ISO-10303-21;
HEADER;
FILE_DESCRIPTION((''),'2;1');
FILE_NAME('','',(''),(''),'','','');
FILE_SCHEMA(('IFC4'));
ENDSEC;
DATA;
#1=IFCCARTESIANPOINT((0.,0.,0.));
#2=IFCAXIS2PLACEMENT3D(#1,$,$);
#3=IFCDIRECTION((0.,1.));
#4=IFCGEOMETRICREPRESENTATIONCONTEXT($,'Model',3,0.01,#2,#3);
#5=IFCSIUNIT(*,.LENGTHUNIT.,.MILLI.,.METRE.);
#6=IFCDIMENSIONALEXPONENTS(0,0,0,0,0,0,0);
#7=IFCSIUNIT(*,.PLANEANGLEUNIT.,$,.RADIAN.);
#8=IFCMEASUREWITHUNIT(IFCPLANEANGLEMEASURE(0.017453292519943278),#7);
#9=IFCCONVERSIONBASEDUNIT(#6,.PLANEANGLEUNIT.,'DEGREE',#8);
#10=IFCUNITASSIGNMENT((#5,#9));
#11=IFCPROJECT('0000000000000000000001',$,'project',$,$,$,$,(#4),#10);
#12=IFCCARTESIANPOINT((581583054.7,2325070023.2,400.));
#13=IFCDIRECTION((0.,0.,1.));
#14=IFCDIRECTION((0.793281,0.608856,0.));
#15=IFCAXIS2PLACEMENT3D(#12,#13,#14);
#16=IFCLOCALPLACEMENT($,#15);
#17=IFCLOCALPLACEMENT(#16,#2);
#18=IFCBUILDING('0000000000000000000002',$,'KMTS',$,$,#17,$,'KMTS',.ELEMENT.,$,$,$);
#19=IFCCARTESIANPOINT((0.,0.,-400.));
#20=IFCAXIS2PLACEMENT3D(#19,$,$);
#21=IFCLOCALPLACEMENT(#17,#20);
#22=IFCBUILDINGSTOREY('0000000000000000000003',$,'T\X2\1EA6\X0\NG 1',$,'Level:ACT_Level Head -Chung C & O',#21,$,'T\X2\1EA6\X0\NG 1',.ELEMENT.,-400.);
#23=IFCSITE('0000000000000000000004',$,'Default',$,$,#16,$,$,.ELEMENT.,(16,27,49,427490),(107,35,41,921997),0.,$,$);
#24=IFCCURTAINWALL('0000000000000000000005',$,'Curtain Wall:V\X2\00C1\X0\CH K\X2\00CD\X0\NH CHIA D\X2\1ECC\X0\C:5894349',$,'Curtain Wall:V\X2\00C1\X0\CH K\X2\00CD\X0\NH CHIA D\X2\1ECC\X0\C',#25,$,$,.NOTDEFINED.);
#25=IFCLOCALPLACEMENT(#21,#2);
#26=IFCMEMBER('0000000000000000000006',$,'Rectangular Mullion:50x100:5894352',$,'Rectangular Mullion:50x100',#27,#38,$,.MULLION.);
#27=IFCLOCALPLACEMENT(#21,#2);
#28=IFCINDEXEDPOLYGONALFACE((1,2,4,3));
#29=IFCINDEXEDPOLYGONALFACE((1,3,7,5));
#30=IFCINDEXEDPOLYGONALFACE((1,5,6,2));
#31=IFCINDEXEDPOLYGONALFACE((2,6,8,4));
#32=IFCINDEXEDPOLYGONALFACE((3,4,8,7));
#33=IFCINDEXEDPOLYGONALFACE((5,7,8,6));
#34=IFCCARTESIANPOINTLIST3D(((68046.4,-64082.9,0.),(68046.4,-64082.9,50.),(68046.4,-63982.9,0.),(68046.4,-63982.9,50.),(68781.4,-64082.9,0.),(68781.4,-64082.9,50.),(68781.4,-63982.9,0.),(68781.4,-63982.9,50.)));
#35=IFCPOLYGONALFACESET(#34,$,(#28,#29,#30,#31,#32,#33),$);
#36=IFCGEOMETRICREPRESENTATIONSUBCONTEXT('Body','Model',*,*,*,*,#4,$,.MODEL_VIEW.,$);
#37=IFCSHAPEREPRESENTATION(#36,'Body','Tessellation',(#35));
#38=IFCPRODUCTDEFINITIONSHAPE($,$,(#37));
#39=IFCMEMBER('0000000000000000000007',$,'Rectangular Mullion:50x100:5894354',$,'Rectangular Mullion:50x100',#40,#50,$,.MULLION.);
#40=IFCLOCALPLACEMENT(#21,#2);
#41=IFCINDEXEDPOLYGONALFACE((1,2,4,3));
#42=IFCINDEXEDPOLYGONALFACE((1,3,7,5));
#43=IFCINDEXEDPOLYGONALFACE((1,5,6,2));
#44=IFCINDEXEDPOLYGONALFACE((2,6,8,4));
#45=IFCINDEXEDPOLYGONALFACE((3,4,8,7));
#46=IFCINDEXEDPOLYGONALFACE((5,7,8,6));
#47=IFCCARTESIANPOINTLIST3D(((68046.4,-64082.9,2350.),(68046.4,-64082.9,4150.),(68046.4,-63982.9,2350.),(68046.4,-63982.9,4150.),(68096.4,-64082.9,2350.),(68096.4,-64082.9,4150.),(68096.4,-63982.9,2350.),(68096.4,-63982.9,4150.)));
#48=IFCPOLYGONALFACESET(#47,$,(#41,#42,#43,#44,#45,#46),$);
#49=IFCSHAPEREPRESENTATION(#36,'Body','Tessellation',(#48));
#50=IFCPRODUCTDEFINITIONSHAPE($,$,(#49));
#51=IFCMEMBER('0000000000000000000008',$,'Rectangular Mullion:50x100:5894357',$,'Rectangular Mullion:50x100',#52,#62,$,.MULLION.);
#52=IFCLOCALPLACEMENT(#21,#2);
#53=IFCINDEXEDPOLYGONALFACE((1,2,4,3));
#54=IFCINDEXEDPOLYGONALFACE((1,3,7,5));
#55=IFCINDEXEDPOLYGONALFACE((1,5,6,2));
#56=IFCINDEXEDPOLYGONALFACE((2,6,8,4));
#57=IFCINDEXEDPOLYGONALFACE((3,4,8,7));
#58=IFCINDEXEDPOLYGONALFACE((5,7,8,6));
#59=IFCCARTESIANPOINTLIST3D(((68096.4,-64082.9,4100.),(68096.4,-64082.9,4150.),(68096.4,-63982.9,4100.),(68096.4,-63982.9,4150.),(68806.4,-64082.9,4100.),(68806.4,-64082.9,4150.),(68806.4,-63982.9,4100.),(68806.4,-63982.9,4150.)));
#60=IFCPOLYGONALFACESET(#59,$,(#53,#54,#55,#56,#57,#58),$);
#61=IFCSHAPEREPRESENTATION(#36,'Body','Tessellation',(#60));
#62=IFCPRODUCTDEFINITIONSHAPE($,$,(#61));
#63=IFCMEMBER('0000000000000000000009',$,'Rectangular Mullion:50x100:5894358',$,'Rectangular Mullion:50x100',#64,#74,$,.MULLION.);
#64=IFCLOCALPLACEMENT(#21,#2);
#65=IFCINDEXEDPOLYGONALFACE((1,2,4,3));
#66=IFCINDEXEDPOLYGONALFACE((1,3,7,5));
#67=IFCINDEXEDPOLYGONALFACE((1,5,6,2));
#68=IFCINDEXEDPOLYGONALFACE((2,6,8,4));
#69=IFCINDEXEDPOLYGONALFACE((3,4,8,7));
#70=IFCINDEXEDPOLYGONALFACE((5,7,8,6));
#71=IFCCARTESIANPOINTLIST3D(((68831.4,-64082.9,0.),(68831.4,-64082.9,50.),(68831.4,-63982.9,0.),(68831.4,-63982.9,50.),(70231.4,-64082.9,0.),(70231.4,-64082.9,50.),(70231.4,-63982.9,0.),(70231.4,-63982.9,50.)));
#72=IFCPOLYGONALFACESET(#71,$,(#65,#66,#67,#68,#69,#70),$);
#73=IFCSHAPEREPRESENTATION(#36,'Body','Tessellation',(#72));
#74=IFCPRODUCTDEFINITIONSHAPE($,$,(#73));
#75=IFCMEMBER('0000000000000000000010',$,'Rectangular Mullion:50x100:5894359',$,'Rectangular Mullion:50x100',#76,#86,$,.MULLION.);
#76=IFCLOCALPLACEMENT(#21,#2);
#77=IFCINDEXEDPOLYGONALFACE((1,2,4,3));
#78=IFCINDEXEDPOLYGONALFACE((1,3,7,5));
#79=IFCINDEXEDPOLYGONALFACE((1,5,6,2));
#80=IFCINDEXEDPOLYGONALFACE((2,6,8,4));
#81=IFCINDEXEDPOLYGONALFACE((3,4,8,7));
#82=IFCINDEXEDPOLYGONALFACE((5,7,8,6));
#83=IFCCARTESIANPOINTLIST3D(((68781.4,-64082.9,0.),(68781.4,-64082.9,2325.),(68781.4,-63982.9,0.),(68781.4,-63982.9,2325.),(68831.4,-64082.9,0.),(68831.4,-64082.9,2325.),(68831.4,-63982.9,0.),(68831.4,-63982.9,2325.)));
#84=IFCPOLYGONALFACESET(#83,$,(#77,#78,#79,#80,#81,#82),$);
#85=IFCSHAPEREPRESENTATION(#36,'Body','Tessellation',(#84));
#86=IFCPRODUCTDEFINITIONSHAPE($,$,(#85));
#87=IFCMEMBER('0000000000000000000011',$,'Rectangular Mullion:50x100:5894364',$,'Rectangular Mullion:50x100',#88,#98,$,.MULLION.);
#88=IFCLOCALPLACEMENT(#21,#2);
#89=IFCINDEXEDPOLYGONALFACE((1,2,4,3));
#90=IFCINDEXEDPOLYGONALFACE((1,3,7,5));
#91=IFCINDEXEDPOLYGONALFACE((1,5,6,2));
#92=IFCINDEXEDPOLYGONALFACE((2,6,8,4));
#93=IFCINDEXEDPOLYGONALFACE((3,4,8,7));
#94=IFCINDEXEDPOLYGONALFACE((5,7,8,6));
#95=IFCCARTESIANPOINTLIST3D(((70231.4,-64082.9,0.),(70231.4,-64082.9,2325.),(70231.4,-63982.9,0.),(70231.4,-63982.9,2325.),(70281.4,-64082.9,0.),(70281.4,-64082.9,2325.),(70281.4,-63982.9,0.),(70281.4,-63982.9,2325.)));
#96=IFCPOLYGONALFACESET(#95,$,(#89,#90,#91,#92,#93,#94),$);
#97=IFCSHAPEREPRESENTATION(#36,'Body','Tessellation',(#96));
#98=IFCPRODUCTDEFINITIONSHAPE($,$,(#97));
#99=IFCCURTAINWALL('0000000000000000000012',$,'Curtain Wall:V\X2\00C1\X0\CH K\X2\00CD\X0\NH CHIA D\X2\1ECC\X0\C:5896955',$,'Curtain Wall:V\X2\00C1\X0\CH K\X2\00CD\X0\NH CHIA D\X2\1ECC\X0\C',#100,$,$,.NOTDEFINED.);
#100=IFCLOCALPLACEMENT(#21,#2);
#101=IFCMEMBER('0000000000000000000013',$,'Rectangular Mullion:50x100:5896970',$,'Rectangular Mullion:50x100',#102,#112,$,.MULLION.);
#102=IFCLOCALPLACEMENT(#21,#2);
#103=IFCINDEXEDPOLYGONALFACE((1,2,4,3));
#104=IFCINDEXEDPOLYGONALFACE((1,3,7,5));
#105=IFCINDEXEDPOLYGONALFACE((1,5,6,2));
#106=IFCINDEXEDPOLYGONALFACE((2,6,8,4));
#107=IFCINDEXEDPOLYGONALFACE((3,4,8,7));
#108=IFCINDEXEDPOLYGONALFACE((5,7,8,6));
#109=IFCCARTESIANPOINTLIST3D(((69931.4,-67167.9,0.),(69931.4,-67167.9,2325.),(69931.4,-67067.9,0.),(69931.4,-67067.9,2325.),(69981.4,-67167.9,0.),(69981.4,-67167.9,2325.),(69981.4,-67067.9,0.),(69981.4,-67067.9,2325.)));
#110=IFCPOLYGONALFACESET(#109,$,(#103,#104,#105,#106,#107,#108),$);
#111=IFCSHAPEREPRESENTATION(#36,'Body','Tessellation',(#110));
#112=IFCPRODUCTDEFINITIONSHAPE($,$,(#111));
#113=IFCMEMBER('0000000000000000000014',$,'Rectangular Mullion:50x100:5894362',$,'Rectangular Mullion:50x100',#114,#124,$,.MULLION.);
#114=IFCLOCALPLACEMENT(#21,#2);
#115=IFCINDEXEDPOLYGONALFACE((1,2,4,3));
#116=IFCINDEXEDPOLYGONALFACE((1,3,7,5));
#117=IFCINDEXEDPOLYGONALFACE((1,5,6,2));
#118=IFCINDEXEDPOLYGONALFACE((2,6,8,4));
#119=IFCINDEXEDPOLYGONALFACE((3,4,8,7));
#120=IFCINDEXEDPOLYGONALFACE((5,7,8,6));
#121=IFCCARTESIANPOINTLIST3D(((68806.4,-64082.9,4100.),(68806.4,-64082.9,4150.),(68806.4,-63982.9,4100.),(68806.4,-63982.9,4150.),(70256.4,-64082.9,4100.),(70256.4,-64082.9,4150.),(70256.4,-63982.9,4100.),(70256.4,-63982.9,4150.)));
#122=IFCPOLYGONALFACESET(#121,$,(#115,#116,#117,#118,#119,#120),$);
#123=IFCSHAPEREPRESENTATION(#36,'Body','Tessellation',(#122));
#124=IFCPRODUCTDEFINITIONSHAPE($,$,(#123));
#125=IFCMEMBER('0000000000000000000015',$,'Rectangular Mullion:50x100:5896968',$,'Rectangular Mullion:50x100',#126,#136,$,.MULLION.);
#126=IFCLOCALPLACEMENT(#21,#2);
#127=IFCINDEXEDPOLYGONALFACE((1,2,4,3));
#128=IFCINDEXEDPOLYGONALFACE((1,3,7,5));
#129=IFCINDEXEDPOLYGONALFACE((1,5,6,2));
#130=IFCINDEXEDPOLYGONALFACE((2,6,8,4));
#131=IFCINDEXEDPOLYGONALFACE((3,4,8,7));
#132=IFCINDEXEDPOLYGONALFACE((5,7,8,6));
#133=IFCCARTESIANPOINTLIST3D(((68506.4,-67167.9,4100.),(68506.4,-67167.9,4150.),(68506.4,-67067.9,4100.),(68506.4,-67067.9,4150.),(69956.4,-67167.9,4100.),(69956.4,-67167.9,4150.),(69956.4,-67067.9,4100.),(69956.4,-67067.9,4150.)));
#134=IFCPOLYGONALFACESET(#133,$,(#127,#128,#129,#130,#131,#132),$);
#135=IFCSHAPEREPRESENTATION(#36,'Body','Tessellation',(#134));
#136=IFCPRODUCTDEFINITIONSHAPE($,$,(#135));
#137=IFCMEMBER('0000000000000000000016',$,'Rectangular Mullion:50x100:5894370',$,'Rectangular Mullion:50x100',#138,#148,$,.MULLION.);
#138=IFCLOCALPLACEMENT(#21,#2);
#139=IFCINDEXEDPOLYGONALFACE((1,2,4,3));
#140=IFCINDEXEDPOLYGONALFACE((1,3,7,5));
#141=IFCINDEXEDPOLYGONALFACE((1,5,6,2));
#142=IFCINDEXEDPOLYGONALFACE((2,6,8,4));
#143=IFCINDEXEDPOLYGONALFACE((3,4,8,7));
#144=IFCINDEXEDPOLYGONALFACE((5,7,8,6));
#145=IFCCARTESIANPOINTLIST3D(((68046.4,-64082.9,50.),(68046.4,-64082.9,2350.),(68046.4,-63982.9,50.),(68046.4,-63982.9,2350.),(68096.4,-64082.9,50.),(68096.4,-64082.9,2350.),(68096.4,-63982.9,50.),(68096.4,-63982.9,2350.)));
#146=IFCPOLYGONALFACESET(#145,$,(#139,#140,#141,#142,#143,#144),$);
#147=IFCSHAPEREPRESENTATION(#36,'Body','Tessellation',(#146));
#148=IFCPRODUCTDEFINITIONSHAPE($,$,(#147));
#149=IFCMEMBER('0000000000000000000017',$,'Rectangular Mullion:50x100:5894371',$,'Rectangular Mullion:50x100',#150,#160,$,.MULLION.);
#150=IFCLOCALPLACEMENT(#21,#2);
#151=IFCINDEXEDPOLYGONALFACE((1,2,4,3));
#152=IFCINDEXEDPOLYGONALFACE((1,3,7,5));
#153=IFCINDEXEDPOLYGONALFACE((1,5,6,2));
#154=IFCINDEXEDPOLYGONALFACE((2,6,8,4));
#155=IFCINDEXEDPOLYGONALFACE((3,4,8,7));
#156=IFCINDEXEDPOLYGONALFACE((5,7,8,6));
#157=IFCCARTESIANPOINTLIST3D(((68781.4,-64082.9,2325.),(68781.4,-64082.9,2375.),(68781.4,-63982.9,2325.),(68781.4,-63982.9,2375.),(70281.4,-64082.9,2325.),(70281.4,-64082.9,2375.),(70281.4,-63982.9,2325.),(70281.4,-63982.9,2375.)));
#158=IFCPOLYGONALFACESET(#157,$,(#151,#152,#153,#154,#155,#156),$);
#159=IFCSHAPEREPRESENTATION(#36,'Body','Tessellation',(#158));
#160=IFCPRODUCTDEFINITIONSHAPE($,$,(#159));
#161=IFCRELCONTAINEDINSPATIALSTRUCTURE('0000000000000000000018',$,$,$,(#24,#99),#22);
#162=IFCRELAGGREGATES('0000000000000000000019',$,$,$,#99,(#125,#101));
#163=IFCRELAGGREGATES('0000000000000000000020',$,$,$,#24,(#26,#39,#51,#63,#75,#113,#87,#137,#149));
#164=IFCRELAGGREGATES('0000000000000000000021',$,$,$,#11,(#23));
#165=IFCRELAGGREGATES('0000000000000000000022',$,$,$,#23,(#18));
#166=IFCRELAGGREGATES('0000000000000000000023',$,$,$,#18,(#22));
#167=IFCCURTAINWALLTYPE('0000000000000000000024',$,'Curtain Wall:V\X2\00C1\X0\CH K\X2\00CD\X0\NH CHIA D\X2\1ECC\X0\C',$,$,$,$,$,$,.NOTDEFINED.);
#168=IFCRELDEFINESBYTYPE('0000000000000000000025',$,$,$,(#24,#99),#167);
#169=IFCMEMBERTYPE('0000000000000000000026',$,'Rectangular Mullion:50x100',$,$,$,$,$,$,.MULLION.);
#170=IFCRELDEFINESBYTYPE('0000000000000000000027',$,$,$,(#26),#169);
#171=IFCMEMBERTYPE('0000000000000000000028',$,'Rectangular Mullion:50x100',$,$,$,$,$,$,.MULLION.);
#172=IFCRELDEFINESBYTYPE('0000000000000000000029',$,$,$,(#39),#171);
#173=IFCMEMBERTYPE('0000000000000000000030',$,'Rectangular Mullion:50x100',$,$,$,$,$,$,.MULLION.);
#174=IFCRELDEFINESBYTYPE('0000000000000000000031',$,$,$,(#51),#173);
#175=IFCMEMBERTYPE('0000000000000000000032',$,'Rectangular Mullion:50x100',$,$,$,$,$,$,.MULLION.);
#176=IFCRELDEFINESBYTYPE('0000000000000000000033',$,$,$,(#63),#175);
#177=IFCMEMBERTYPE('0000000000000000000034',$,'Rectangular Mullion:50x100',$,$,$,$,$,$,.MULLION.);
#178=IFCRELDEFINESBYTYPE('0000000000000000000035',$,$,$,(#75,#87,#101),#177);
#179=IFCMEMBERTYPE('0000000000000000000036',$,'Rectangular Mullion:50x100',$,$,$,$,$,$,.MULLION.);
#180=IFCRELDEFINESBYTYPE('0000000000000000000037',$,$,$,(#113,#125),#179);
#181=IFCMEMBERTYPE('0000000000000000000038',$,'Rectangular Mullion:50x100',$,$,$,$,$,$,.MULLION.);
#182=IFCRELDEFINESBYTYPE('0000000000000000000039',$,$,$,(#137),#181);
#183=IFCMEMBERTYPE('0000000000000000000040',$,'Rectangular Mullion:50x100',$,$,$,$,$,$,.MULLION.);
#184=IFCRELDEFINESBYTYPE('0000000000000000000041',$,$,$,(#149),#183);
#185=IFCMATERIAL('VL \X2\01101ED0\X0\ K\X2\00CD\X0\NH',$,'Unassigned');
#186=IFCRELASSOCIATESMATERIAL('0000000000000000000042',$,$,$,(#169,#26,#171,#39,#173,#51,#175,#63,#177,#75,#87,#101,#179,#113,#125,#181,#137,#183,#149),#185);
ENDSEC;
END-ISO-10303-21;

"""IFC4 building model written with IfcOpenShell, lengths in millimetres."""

from ifc_helpers import new_model, entity, si_unit, converted_unit, direction, frame, origin, place, context, subcontext, project, spatial, indexed_curve, outline, extrude, source, transform, mapped, material, type_object, type_shapes, element, aggregate, save


model = new_model("IFC4")

# Units and contexts
model_context = context("Model", 3, precision=0.01, world=origin(), true_north=direction((0.0, 1.0)))
body_context = subcontext(model_context, "Body", "Model", "MODEL_VIEW")
ifc_project = project(units=[si_unit("LENGTHUNIT", "METRE", prefix="MILLI"), converted_unit("PLANEANGLEUNIT", "DEGREE", entity("IfcPlaneAngleMeasure", 0.017453292519943278), si_unit("PLANEANGLEUNIT", "RADIAN"), dimensions=[0, 0, 0, 0, 0, 0, 0])], contexts=[model_context])

# Site, building, storey
site_placement = place(None, frame((581583054.7, 2325070023.2, 400.0), z_axis=(0.0, 0.0, 1.0), x_axis=(0.793281, 0.608856, 0.0)))
site = spatial("IfcSite", under=ifc_project, at=site_placement, Name="Default", CompositionType="ELEMENT", RefLatitude=(16, 27, 49, 427490), RefLongitude=(107, 35, 41, 921997), RefElevation=0.0)
building_placement = place(site_placement, origin())
building = spatial("IfcBuilding", under=site, at=building_placement, Name="KMTS", LongName="KMTS", CompositionType="ELEMENT")
storey_placement = place(building_placement, frame((0.0, 0.0, -400.0)))
storey = spatial("IfcBuildingStorey", under=building, at=storey_placement, Name="TẦNG 1", ObjectType="Level:ACT_Level Head -Chung C & O", LongName="TẦNG 1", CompositionType="ELEMENT", Elevation=-400.0)

# Curtain wall, members
curtain_wall_type = type_object("IfcCurtainWallType", Name="Curtain Wall:VÁCH KÍNH CHIA DỌC", PredefinedType="NOTDEFINED")
curtain_wall_1_placement = place(storey_placement, frame((0.0, 0.0, 400.0)))
curtain_wall_1 = element("IfcCurtainWall", 1, at=curtain_wall_1_placement, inside=storey, type_object=curtain_wall_type, Name="Curtain Wall:VÁCH KÍNH CHIA DỌC:5894349", ObjectType="Curtain Wall:VÁCH KÍNH CHIA DỌC", PredefinedType="NOTDEFINED")
ifc_material_1 = material(Name="VL ĐỐ KÍNH", Category="Unassigned")
member_type_1 = type_object("IfcMemberType", Name="Rectangular Mullion:50x100", PredefinedType="MULLION", material=ifc_material_1)
shared_shape_1 = source(origin(), body_context, "Body", "SweptSolid", [
    extrude(outline(indexed_curve([(-25.0, -50.0), (25.0, -50.0), (25.0, 50.0), (-25.0, 50.0), (-25.0, -50.0)], self_intersect=False)), frame((-25.0, 0.0, -735.0), z_axis=(0.0, 0.0, 1.0), x_axis=(-1.0, 0.0, 0.0)), (0.0, 0.0, 1.0), 735.0),
])
type_shapes(member_type_1, [shared_shape_1])
member_1_placement = place(curtain_wall_1_placement, frame((68046.4, -64032.9, -400.0), z_axis=(-1.0, 0.0, 0.0), x_axis=(0.0, 0.0, -1.0)))
member_1 = element("IfcMember", 2, at=member_1_placement, type_object=member_type_1, material=ifc_material_1, Name="Rectangular Mullion:50x100:5894352", ObjectType="Rectangular Mullion:50x100", PredefinedType="MULLION", context=body_context, shape_type="MappedRepresentation", body=[
    mapped(shared_shape_1, transform((0.0, 0.0, 0.0), scale=1.0)),
])
member_type_2 = type_object("IfcMemberType", Name="Rectangular Mullion:50x100", PredefinedType="MULLION", material=ifc_material_1)
shared_shape_2 = source(origin(), body_context, "Body", "SweptSolid", [
    extrude(outline(indexed_curve([(-25.0, -50.0), (25.0, -50.0), (25.0, 50.0), (-25.0, 50.0), (-25.0, -50.0)], self_intersect=False)), frame((-25.0, 0.0, -1800.0), z_axis=(0.0, 0.0, 1.0), x_axis=(-1.0, 0.0, 0.0)), (0.0, 0.0, 1.0), 1800.0),
])
type_shapes(member_type_2, [shared_shape_2])
member_2_placement = place(curtain_wall_1_placement, frame((68046.4, -64032.9, 3750.0), z_axis=(0.0, 0.0, 1.0), x_axis=(-1.0, 0.0, 0.0)))
member_2 = element("IfcMember", 3, at=member_2_placement, type_object=member_type_2, material=ifc_material_1, Name="Rectangular Mullion:50x100:5894354", ObjectType="Rectangular Mullion:50x100", PredefinedType="MULLION", context=body_context, shape_type="MappedRepresentation", body=[
    mapped(shared_shape_2, transform((0.0, 0.0, 0.0), scale=1.0)),
])
member_type_3 = type_object("IfcMemberType", Name="Rectangular Mullion:50x100", PredefinedType="MULLION", material=ifc_material_1)
shared_shape_3 = source(origin(), body_context, "Body", "SweptSolid", [
    extrude(outline(indexed_curve([(-25.0, -50.0), (25.0, -50.0), (25.0, 50.0), (-25.0, 50.0), (-25.0, -50.0)], self_intersect=False)), frame((-25.0, 0.0, -710.0), z_axis=(0.0, 0.0, 1.0), x_axis=(-1.0, 0.0, 0.0)), (0.0, 0.0, 1.0), 710.0),
])
type_shapes(member_type_3, [shared_shape_3])
member_3_placement = place(curtain_wall_1_placement, frame((68806.4, -64032.9, 3750.0), z_axis=(1.0, 0.0, 0.0), x_axis=(0.0, 0.0, 1.0)))
member_3 = element("IfcMember", 4, at=member_3_placement, type_object=member_type_3, material=ifc_material_1, Name="Rectangular Mullion:50x100:5894357", ObjectType="Rectangular Mullion:50x100", PredefinedType="MULLION", context=body_context, shape_type="MappedRepresentation", body=[
    mapped(shared_shape_3, transform((0.0, 0.0, 0.0), scale=1.0)),
])
member_type_4 = type_object("IfcMemberType", Name="Rectangular Mullion:50x100", PredefinedType="MULLION", material=ifc_material_1)
shared_shape_4 = source(origin(), body_context, "Body", "SweptSolid", [
    extrude(outline(indexed_curve([(-25.0, -50.0), (25.0, -50.0), (25.0, 50.0), (-25.0, 50.0), (-25.0, -50.0)], self_intersect=False)), frame((-25.0, 0.0, -1400.0), z_axis=(0.0, 0.0, 1.0), x_axis=(-1.0, 0.0, 0.0)), (0.0, 0.0, 1.0), 1400.0),
])
type_shapes(member_type_4, [shared_shape_4])
member_4_placement = place(curtain_wall_1_placement, frame((68831.4, -64032.9, -400.0), z_axis=(-1.0, 0.0, 0.0), x_axis=(0.0, 0.0, -1.0)))
member_4 = element("IfcMember", 5, at=member_4_placement, type_object=member_type_4, material=ifc_material_1, Name="Rectangular Mullion:50x100:5894358", ObjectType="Rectangular Mullion:50x100", PredefinedType="MULLION", context=body_context, shape_type="MappedRepresentation", body=[
    mapped(shared_shape_4, transform((0.0, 0.0, 0.0), scale=1.0)),
])
member_type_5 = type_object("IfcMemberType", Name="Rectangular Mullion:50x100", PredefinedType="MULLION", material=ifc_material_1)
shared_shape_5 = source(origin(), body_context, "Body", "SweptSolid", [
    extrude(outline(indexed_curve([(-25.0, -50.0), (25.0, -50.0), (25.0, 50.0), (-25.0, 50.0), (-25.0, -50.0)], self_intersect=False)), frame((0.0, 0.0, -2325.0), z_axis=(0.0, 0.0, 1.0), x_axis=(-1.0, 0.0, 0.0)), (0.0, 0.0, 1.0), 2325.0),
])
type_shapes(member_type_5, [shared_shape_5])
member_5_placement = place(curtain_wall_1_placement, frame((68806.4, -64032.9, -400.0), z_axis=(0.0, 0.0, -1.0), x_axis=(1.0, 0.0, 0.0)))
member_5 = element("IfcMember", 6, at=member_5_placement, type_object=member_type_5, material=ifc_material_1, Name="Rectangular Mullion:50x100:5894359", ObjectType="Rectangular Mullion:50x100", PredefinedType="MULLION", context=body_context, shape_type="MappedRepresentation", body=[
    mapped(shared_shape_5, transform((0.0, 0.0, 0.0), scale=1.0)),
])
member_6_placement = place(curtain_wall_1_placement, frame((70256.4, -64032.9, -400.0), z_axis=(0.0, 0.0, -1.0), x_axis=(1.0, 0.0, 0.0)))
member_6 = element("IfcMember", 7, at=member_6_placement, type_object=member_type_5, material=ifc_material_1, Name="Rectangular Mullion:50x100:5894364", ObjectType="Rectangular Mullion:50x100", PredefinedType="MULLION", context=body_context, shape_type="MappedRepresentation", body=[
    mapped(shared_shape_5, transform((0.0, 0.0, 0.0), scale=1.0)),
])

# Curtain wall, member
curtain_wall_2_placement = place(storey_placement, frame((0.0, 0.0, 400.0)))
curtain_wall_2 = element("IfcCurtainWall", 8, at=curtain_wall_2_placement, inside=storey, type_object=curtain_wall_type, Name="Curtain Wall:VÁCH KÍNH CHIA DỌC:5896955", ObjectType="Curtain Wall:VÁCH KÍNH CHIA DỌC", PredefinedType="NOTDEFINED")
member_7_placement = place(curtain_wall_2_placement, frame((69956.4, -67117.9, -400.0), z_axis=(0.0, 0.0, -1.0), x_axis=(1.0, 0.0, 0.0)))
member_7 = element("IfcMember", 9, at=member_7_placement, type_object=member_type_5, material=ifc_material_1, Name="Rectangular Mullion:50x100:5896970", ObjectType="Rectangular Mullion:50x100", PredefinedType="MULLION", context=body_context, shape_type="MappedRepresentation", body=[
    mapped(shared_shape_5, transform((0.0, 0.0, 0.0), scale=1.0)),
])

# Members
member_type_6 = type_object("IfcMemberType", Name="Rectangular Mullion:50x100", PredefinedType="MULLION", material=ifc_material_1)
shared_shape_6 = source(origin(), body_context, "Body", "SweptSolid", [
    extrude(outline(indexed_curve([(-25.0, -50.0), (25.0, -50.0), (25.0, 50.0), (-25.0, 50.0), (-25.0, -50.0)], self_intersect=False)), frame((-25.0, 0.0, -1450.0), z_axis=(0.0, 0.0, 1.0), x_axis=(-1.0, 0.0, 0.0)), (0.0, 0.0, 1.0), 1450.0),
])
type_shapes(member_type_6, [shared_shape_6])
member_8_placement = place(curtain_wall_1_placement, frame((70256.4, -64032.9, 3750.0), z_axis=(1.0, 0.0, 0.0), x_axis=(0.0, 0.0, 1.0)))
member_8 = element("IfcMember", 10, at=member_8_placement, type_object=member_type_6, material=ifc_material_1, Name="Rectangular Mullion:50x100:5894362", ObjectType="Rectangular Mullion:50x100", PredefinedType="MULLION", context=body_context, shape_type="MappedRepresentation", body=[
    mapped(shared_shape_6, transform((0.0, 0.0, 0.0), scale=1.0)),
])
member_9_placement = place(curtain_wall_2_placement, frame((69956.4, -67117.9, 3750.0), z_axis=(1.0, 0.0, 0.0), x_axis=(0.0, 0.0, 1.0)))
member_9 = element("IfcMember", 11, at=member_9_placement, type_object=member_type_6, material=ifc_material_1, Name="Rectangular Mullion:50x100:5896968", ObjectType="Rectangular Mullion:50x100", PredefinedType="MULLION", context=body_context, shape_type="MappedRepresentation", body=[
    mapped(shared_shape_6, transform((0.0, 0.0, 0.0), scale=1.0)),
])
member_type_7 = type_object("IfcMemberType", Name="Rectangular Mullion:50x100", PredefinedType="MULLION", material=ifc_material_1)
shared_shape_7 = source(origin(), body_context, "Body", "SweptSolid", [
    extrude(outline(indexed_curve([(-25.0, -50.0), (25.0, -50.0), (25.0, 50.0), (-25.0, 50.0), (-25.0, -50.0)], self_intersect=False)), frame((-25.0, 0.0, -2300.0), z_axis=(0.0, 0.0, 1.0), x_axis=(-1.0, 0.0, 0.0)), (0.0, 0.0, 1.0), 2300.0),
])
type_shapes(member_type_7, [shared_shape_7])
member_10_placement = place(curtain_wall_1_placement, frame((68046.4, -64032.9, 1950.0), z_axis=(0.0, 0.0, 1.0), x_axis=(-1.0, 0.0, 0.0)))
member_10 = element("IfcMember", 12, at=member_10_placement, type_object=member_type_7, material=ifc_material_1, Name="Rectangular Mullion:50x100:5894370", ObjectType="Rectangular Mullion:50x100", PredefinedType="MULLION", context=body_context, shape_type="MappedRepresentation", body=[
    mapped(shared_shape_7, transform((0.0, 0.0, 0.0), scale=1.0)),
])
member_type_8 = type_object("IfcMemberType", Name="Rectangular Mullion:50x100", PredefinedType="MULLION", material=ifc_material_1)
shared_shape_8 = source(origin(), body_context, "Body", "SweptSolid", [
    extrude(outline(indexed_curve([(-25.0, -50.0), (25.0, -50.0), (25.0, 50.0), (-25.0, 50.0), (-25.0, -50.0)], self_intersect=False)), frame((0.0, 0.0, -1500.0), z_axis=(0.0, 0.0, 1.0), x_axis=(-1.0, 0.0, 0.0)), (0.0, 0.0, 1.0), 1500.0),
])
type_shapes(member_type_8, [shared_shape_8])
member_11_placement = place(curtain_wall_1_placement, frame((70281.4, -64032.9, 1950.0), z_axis=(1.0, 0.0, 0.0), x_axis=(0.0, 0.0, 1.0)))
member_11 = element("IfcMember", 13, at=member_11_placement, type_object=member_type_8, material=ifc_material_1, Name="Rectangular Mullion:50x100:5894371", ObjectType="Rectangular Mullion:50x100", PredefinedType="MULLION", context=body_context, shape_type="MappedRepresentation", body=[
    mapped(shared_shape_8, transform((0.0, 0.0, 0.0), scale=1.0)),
])

aggregate(curtain_wall_2, [member_9, member_7])

aggregate(curtain_wall_1, [member_1, member_2, member_3, member_4, member_5, member_8, member_6, member_10, member_11])

save(model, "model.ifc")
